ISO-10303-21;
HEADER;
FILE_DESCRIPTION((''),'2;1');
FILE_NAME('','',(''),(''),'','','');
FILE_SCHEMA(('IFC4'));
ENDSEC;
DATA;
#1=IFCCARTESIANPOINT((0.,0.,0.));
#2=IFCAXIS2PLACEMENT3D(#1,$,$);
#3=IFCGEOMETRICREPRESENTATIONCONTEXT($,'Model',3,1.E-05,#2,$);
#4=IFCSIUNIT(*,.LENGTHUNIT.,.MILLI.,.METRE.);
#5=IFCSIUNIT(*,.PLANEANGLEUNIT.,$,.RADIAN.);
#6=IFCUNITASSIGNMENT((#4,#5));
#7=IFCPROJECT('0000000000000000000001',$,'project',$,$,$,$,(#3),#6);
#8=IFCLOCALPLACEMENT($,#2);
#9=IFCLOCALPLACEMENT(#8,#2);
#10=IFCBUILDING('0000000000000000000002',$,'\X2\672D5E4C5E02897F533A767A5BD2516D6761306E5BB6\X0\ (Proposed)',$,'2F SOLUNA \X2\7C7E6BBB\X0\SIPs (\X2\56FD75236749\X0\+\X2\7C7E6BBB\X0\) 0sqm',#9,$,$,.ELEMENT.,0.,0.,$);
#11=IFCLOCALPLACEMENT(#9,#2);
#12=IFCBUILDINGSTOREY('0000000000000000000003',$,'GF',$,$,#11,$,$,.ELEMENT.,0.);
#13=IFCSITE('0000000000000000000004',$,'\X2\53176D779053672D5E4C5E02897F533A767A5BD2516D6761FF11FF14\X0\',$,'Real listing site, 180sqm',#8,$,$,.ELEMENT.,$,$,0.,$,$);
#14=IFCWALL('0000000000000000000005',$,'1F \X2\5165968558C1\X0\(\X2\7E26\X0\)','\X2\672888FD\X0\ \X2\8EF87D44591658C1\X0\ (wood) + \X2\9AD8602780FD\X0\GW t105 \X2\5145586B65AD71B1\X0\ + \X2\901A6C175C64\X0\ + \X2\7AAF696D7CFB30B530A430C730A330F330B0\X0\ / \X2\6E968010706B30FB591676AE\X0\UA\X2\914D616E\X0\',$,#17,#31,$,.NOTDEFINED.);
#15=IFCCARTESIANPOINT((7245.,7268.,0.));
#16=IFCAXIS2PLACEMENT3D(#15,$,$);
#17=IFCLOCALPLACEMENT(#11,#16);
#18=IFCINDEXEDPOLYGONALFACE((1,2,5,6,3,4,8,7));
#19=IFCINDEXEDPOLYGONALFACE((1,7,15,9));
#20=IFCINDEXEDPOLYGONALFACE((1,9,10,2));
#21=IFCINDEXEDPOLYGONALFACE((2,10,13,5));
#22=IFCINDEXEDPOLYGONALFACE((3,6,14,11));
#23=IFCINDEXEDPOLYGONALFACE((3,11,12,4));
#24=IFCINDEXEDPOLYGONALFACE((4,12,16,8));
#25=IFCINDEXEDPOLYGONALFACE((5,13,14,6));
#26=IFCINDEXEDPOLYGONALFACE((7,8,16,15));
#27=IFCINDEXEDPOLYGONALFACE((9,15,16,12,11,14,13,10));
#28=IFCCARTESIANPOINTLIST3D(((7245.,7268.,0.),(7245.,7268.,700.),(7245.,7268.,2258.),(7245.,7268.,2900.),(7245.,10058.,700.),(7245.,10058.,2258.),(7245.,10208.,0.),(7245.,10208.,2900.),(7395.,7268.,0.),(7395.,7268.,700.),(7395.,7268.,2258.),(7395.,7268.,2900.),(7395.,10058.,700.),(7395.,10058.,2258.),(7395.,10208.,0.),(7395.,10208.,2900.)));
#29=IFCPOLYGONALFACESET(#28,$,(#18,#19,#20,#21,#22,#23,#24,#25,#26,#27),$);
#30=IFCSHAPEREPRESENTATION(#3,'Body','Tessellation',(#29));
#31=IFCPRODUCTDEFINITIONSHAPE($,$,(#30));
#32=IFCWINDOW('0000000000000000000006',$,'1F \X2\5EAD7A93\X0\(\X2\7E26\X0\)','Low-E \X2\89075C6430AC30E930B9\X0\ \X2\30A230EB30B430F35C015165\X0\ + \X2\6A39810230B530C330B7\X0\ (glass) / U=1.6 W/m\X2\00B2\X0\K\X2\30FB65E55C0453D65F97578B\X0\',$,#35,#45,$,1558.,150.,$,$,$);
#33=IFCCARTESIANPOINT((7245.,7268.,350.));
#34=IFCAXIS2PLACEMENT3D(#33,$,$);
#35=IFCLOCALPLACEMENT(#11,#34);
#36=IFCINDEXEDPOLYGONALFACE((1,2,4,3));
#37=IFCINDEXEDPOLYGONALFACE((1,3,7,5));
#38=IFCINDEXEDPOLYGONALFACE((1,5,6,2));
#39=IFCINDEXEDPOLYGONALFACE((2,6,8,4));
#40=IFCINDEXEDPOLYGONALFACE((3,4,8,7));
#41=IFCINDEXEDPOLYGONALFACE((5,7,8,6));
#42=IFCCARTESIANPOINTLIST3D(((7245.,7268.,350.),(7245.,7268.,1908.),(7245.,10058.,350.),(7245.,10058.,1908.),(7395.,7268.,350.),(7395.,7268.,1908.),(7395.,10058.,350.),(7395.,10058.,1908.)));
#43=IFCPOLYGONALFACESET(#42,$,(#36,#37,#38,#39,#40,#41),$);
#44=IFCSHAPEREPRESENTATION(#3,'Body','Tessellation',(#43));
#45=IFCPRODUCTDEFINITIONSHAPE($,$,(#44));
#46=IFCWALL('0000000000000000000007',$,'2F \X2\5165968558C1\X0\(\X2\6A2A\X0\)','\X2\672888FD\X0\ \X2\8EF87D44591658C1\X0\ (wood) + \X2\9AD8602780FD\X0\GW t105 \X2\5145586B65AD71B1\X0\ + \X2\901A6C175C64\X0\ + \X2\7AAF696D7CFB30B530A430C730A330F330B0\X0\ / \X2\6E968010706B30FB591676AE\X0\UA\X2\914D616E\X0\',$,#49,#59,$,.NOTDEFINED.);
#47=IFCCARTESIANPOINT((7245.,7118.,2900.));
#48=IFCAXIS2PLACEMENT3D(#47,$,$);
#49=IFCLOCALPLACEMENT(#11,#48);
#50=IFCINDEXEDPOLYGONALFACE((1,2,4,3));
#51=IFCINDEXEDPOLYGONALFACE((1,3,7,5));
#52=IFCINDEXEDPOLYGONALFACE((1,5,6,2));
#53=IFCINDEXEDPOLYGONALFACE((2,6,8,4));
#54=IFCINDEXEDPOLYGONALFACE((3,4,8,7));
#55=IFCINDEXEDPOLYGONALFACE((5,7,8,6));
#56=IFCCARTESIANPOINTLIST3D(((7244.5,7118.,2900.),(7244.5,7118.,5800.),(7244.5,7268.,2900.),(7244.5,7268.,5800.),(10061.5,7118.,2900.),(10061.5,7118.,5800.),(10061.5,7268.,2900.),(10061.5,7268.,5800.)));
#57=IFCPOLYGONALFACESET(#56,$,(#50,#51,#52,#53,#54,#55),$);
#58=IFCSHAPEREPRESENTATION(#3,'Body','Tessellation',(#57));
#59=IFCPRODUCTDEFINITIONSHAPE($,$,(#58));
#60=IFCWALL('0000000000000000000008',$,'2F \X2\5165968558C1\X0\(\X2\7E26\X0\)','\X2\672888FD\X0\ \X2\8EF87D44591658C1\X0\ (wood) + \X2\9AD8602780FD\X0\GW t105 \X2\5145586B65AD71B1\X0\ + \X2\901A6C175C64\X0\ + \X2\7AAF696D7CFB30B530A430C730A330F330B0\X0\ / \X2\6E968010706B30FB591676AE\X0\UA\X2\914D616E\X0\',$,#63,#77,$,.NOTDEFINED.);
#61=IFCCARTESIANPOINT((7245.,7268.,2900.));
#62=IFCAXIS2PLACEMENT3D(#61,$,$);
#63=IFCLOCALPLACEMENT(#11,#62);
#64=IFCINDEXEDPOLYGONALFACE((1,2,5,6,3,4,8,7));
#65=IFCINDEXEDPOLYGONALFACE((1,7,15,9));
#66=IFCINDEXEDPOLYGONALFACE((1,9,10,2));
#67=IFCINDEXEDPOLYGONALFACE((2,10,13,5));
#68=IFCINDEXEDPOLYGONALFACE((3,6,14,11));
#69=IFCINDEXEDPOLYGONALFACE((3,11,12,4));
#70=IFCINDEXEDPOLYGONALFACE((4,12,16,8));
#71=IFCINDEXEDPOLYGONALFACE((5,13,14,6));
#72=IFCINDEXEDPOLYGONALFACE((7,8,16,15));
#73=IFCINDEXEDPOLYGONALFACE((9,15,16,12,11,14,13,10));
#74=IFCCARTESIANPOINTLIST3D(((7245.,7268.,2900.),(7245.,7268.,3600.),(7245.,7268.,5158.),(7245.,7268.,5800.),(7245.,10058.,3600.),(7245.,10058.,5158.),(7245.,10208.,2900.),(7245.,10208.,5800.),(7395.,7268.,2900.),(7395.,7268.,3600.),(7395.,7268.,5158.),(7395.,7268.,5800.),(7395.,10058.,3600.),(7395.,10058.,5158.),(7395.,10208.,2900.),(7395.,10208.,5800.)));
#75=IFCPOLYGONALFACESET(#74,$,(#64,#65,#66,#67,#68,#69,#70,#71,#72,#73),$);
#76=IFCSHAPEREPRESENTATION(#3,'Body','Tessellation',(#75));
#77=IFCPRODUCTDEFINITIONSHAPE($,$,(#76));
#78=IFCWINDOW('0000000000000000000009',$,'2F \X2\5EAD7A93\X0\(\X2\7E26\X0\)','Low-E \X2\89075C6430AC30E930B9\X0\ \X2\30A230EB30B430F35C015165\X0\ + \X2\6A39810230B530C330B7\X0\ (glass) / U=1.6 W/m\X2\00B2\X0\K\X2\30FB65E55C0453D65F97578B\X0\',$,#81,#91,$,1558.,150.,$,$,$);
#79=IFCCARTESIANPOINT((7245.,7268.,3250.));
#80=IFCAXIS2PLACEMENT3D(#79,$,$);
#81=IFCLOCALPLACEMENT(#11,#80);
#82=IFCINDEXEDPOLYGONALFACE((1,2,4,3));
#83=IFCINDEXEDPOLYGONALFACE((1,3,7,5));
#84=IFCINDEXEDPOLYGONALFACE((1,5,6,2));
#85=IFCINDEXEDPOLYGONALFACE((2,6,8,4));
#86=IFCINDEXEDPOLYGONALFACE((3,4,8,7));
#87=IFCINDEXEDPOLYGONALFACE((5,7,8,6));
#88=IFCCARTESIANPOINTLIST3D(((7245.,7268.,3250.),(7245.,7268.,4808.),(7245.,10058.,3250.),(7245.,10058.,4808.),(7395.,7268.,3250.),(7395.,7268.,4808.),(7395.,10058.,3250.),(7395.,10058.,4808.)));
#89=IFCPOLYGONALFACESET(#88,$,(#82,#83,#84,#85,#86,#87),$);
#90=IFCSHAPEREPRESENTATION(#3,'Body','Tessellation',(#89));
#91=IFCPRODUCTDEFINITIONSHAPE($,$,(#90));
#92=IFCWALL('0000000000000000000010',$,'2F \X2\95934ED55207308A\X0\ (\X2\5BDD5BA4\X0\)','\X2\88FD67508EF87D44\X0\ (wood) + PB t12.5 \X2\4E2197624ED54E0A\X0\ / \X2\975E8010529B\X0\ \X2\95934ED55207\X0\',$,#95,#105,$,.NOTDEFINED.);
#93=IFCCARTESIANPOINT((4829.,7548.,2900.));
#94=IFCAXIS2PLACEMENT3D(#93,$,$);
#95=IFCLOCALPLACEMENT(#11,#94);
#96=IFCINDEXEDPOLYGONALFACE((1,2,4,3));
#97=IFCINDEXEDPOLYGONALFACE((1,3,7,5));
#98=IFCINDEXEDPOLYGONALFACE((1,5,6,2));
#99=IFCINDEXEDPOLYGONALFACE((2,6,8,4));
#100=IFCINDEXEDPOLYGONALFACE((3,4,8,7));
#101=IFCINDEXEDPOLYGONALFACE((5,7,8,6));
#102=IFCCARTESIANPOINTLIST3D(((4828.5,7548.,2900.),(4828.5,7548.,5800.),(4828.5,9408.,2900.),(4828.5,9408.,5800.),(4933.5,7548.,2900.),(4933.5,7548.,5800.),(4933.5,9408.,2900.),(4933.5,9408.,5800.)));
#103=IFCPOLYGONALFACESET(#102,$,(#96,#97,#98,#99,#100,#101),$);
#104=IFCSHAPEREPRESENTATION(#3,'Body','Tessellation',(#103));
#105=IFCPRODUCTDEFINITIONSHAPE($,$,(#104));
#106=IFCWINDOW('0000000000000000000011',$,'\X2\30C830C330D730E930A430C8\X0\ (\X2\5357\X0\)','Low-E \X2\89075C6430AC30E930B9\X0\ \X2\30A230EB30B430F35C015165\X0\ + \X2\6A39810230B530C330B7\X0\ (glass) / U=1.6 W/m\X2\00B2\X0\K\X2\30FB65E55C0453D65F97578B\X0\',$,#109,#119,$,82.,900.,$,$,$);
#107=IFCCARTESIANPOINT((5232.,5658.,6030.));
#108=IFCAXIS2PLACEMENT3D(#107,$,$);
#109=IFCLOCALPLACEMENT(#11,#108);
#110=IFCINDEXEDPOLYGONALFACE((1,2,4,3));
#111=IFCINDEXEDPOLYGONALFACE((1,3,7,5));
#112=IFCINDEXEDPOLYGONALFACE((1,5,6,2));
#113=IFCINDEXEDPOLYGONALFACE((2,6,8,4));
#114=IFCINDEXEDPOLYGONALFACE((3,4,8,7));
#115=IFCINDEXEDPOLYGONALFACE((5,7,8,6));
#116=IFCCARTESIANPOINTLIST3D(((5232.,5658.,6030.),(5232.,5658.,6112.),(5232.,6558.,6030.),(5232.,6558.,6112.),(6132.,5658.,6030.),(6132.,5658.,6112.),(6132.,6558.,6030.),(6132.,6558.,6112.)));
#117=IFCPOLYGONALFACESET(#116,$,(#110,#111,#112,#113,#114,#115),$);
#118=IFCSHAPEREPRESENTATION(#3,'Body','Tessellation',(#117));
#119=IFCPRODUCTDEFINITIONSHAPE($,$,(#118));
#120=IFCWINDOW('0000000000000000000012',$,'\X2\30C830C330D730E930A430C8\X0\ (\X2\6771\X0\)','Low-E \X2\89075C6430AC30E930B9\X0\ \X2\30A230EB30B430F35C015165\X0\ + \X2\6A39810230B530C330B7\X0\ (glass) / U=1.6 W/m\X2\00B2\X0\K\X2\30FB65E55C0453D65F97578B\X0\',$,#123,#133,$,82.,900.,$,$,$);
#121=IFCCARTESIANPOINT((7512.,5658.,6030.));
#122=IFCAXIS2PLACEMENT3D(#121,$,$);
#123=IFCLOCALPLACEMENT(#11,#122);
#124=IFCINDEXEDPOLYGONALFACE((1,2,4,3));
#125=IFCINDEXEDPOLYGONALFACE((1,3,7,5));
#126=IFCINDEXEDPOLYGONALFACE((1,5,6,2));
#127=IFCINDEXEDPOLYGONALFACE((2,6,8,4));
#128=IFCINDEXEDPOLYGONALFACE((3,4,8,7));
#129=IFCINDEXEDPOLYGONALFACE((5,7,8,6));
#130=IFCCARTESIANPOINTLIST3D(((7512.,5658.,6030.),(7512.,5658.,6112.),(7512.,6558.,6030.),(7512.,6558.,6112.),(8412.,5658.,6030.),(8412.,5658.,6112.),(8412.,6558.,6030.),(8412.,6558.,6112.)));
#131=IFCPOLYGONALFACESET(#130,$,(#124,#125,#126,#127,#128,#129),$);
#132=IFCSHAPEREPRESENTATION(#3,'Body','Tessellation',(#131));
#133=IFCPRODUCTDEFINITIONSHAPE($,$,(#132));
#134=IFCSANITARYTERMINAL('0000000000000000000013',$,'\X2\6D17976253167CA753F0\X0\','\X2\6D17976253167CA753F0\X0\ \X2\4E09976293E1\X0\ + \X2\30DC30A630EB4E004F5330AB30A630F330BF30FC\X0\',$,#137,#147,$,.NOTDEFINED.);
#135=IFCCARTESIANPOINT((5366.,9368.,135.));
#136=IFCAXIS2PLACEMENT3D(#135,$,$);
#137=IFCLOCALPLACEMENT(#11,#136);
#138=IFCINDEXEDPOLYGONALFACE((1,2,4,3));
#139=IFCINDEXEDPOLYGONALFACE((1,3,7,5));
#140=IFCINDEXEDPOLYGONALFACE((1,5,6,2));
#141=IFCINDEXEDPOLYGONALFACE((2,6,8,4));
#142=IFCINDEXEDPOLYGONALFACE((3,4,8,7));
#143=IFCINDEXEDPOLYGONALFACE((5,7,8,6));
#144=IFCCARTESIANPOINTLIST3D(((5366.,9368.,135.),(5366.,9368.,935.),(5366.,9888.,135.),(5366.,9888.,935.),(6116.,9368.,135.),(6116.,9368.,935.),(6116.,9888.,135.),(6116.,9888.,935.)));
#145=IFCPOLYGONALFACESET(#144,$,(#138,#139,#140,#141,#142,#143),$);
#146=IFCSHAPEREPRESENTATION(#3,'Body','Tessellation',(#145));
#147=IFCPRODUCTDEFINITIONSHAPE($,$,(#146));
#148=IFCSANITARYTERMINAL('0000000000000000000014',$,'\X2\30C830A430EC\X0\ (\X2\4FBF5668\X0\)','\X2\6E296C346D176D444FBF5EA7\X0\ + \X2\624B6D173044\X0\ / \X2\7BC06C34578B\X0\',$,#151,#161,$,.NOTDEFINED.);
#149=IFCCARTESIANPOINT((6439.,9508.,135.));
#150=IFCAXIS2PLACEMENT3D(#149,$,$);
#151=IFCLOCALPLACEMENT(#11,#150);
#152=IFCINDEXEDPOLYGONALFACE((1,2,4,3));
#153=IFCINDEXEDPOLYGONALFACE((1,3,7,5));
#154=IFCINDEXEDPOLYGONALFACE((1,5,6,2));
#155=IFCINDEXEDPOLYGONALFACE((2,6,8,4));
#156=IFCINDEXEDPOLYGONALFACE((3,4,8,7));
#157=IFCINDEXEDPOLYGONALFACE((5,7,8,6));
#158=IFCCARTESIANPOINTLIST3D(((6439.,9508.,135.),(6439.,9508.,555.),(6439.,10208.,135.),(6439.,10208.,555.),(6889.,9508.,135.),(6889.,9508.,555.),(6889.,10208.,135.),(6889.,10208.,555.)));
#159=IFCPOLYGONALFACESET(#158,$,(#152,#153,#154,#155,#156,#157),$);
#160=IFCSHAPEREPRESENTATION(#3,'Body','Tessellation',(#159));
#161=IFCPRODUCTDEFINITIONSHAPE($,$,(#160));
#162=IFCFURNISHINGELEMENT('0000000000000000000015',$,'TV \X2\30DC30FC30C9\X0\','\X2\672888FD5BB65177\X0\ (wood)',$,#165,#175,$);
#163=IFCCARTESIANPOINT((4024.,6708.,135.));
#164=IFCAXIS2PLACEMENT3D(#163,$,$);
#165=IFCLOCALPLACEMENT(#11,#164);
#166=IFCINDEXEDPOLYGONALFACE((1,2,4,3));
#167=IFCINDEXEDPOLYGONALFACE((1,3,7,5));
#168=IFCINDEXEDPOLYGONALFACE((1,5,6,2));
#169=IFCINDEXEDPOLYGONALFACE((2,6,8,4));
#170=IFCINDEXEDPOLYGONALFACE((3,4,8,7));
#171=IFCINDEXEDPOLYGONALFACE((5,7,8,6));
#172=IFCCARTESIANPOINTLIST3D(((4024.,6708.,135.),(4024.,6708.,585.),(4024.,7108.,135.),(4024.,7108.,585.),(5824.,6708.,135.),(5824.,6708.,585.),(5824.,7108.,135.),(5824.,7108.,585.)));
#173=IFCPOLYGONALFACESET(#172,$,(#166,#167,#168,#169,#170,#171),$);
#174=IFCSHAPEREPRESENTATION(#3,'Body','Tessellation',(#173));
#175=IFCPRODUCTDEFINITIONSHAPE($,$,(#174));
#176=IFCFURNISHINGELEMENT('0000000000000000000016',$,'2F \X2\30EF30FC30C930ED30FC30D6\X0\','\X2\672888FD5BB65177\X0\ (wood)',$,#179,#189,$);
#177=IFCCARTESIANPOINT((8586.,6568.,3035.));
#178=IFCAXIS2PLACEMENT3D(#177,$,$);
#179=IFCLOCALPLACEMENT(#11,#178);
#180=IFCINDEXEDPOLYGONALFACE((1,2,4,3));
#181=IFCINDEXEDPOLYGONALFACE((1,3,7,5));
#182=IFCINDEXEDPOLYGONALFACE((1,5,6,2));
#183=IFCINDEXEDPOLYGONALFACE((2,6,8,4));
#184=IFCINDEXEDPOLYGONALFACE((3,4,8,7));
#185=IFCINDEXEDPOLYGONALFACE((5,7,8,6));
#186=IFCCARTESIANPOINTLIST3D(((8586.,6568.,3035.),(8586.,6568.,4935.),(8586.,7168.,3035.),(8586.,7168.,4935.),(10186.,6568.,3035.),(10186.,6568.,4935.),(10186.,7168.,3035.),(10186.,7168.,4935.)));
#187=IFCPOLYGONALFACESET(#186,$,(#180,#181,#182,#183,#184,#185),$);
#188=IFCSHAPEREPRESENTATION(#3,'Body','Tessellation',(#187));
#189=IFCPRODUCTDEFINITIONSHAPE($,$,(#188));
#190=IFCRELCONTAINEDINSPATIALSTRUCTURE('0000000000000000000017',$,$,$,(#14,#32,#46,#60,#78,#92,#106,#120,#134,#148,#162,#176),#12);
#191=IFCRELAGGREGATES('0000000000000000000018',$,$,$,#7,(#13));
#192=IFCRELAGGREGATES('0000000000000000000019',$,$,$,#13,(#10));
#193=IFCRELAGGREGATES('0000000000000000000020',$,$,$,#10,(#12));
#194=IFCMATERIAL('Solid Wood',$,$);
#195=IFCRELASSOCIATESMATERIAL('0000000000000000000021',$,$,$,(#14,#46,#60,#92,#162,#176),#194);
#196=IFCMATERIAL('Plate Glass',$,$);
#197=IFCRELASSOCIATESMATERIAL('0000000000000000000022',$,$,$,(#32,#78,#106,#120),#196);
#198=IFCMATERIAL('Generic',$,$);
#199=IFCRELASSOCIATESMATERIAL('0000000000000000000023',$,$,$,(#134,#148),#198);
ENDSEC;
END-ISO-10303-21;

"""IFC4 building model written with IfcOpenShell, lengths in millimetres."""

from ifc_helpers import new_model, si_unit, frame, frame_2d, origin, place, context, project, spatial, rectangle, extrude, material, element, fill, save


model = new_model("IFC4")

# Units and contexts
model_context = context("Model", 3, precision=1e-05, world=origin())
ifc_project = project(units=[si_unit("LENGTHUNIT", "METRE", prefix="MILLI"), si_unit("PLANEANGLEUNIT", "RADIAN")], contexts=[model_context])

# Site, building, storey
site_placement = place(None, origin())
site = spatial("IfcSite", under=ifc_project, at=site_placement, Name="北海道札幌市西区発寒六条１４", ObjectType="Real listing site, 180sqm", CompositionType="ELEMENT", RefElevation=0.0)
building_placement = place(site_placement, origin())
building = spatial("IfcBuilding", under=site, at=building_placement, Name="札幌市西区発寒六条の家 (Proposed)", ObjectType="2F SOLUNA 籾殻SIPs (国産杉+籾殻) 0sqm", CompositionType="ELEMENT", ElevationOfRefHeight=0.0, ElevationOfTerrain=0.0)
storey_placement = place(building_placement, origin())
storey = spatial("IfcBuildingStorey", under=building, at=storey_placement, Name="GF", CompositionType="ELEMENT", Elevation=0.0)

# Shared definitions
ifc_material_1 = material(Name="Solid Wood")

# Wall, opening, window
wall_1_placement = place(storey_placement, frame((7245.0, 7268.0, 0.0)))
wall_1 = element("IfcWall", 1, at=wall_1_placement, inside=storey, material=ifc_material_1, Name="1F 入隅壁(縦)", Description="木製 軸組外壁 (wood) + 高性能GW t105 充填断熱 + 通気層 + 窯業系サイディング / 準耐火・外皮UA配慮", PredefinedType="NOTDEFINED", context=model_context, shape_type="SweptSolid", body=[
    extrude(rectangle(XDim=150.0, YDim=2940.0, at=frame_2d((75.0, 1470.0))), frame((7245.0, 7268.0, 0.0)), (0.0, 0.0, 1.0), 2900.0),
])
opening_1_placement = place(storey_placement, frame((7245.0, 7268.0, 350.0)))
opening_1 = element("IfcOpeningElement", 2, at=opening_1_placement, cuts=wall_1, PredefinedType="NOTDEFINED", context=model_context, shape_type="SweptSolid", body=[
    extrude(rectangle(XDim=150.0, YDim=2790.0, at=frame_2d((75.0, 1395.0))), frame((7245.0, 7268.0, 350.0)), (0.0, 0.0, 1.0), 1558.0),
])
ifc_material_2 = material(Name="Plate Glass")
window_1_placement = place(storey_placement, frame((7245.0, 7268.0, 350.0)))
window_1 = element("IfcWindow", 3, at=window_1_placement, inside=storey, material=ifc_material_2, Name="1F 庭窓(縦)", Description="Low-E 複層ガラス アルゴン封入 + 樹脂サッシ (glass) / U=1.6 W/m²K・日射取得型", OverallHeight=1558.0, OverallWidth=150.0, context=model_context, shape_type="SweptSolid", body=[
    extrude(rectangle(XDim=150.0, YDim=2790.0, at=frame_2d((75.0, 1395.0))), frame((7245.0, 7268.0, 350.0)), (0.0, 0.0, 1.0), 1558.0),
])
fill(opening_1, window_1)

# Wall
wall_2_placement = place(storey_placement, frame((7245.0, 7118.0, 2900.0)))
element("IfcWall", 4, at=wall_2_placement, inside=storey, material=ifc_material_1, Name="2F 入隅壁(横)", Description="木製 軸組外壁 (wood) + 高性能GW t105 充填断熱 + 通気層 + 窯業系サイディング / 準耐火・外皮UA配慮", PredefinedType="NOTDEFINED", context=model_context, shape_type="SweptSolid", body=[
    extrude(rectangle(XDim=2817.0, YDim=150.0, at=frame_2d((1408.0, 75.0))), frame((7245.0, 7118.0, 2900.0)), (0.0, 0.0, 1.0), 2900.0),
])

# Wall, opening, window
wall_3_placement = place(storey_placement, frame((7245.0, 7268.0, 2900.0)))
wall_3 = element("IfcWall", 5, at=wall_3_placement, inside=storey, material=ifc_material_1, Name="2F 入隅壁(縦)", Description="木製 軸組外壁 (wood) + 高性能GW t105 充填断熱 + 通気層 + 窯業系サイディング / 準耐火・外皮UA配慮", PredefinedType="NOTDEFINED", context=model_context, shape_type="SweptSolid", body=[
    extrude(rectangle(XDim=150.0, YDim=2940.0, at=frame_2d((75.0, 1470.0))), frame((7245.0, 7268.0, 2900.0)), (0.0, 0.0, 1.0), 2900.0),
])
opening_2_placement = place(storey_placement, frame((7245.0, 7268.0, 3250.0)))
opening_2 = element("IfcOpeningElement", 6, at=opening_2_placement, cuts=wall_3, PredefinedType="NOTDEFINED", context=model_context, shape_type="SweptSolid", body=[
    extrude(rectangle(XDim=150.0, YDim=2790.0, at=frame_2d((75.0, 1395.0))), frame((7245.0, 7268.0, 3250.0)), (0.0, 0.0, 1.0), 1558.0),
])
window_2_placement = place(storey_placement, frame((7245.0, 7268.0, 3250.0)))
window_2 = element("IfcWindow", 7, at=window_2_placement, inside=storey, material=ifc_material_2, Name="2F 庭窓(縦)", Description="Low-E 複層ガラス アルゴン封入 + 樹脂サッシ (glass) / U=1.6 W/m²K・日射取得型", OverallHeight=1558.0, OverallWidth=150.0, context=model_context, shape_type="SweptSolid", body=[
    extrude(rectangle(XDim=150.0, YDim=2790.0, at=frame_2d((75.0, 1395.0))), frame((7245.0, 7268.0, 3250.0)), (0.0, 0.0, 1.0), 1558.0),
])
fill(opening_2, window_2)

# Wall
wall_4_placement = place(storey_placement, frame((4829.0, 7548.0, 2900.0)))
element("IfcWall", 8, at=wall_4_placement, inside=storey, material=ifc_material_1, Name="2F 間仕切り (寝室)", Description="製材軸組 (wood) + PB t12.5 両面仕上 / 非耐力 間仕切", PredefinedType="NOTDEFINED", context=model_context, shape_type="SweptSolid", body=[
    extrude(rectangle(XDim=105.0, YDim=1860.0, at=frame_2d((52.0, 930.0))), frame((4829.0, 7548.0, 2900.0)), (0.0, 0.0, 1.0), 2900.0),
])

# Windows
window_3_placement = place(storey_placement, frame((5232.0, 5658.0, 6030.0)))
element("IfcWindow", 9, at=window_3_placement, inside=storey, material=ifc_material_2, Name="トップライト (南)", Description="Low-E 複層ガラス アルゴン封入 + 樹脂サッシ (glass) / U=1.6 W/m²K・日射取得型", OverallHeight=82.0, OverallWidth=900.0, context=model_context, shape_type="SweptSolid", body=[
    extrude(rectangle(XDim=900.0, YDim=900.0, at=frame_2d((450.0, 450.0))), frame((5232.0, 5658.0, 6030.0)), (0.0, 0.0, 1.0), 82.0),
])
window_4_placement = place(storey_placement, frame((7512.0, 5658.0, 6030.0)))
element("IfcWindow", 10, at=window_4_placement, inside=storey, material=ifc_material_2, Name="トップライト (東)", Description="Low-E 複層ガラス アルゴン封入 + 樹脂サッシ (glass) / U=1.6 W/m²K・日射取得型", OverallHeight=82.0, OverallWidth=900.0, context=model_context, shape_type="SweptSolid", body=[
    extrude(rectangle(XDim=900.0, YDim=900.0, at=frame_2d((450.0, 450.0))), frame((7512.0, 5658.0, 6030.0)), (0.0, 0.0, 1.0), 82.0),
])

# Sanitary terminals
ifc_material_3 = material(Name="Generic")
sanitary_terminal_1_placement = place(storey_placement, frame((5366.0, 9368.0, 135.0)))
element("IfcSanitaryTerminal", 11, at=sanitary_terminal_1_placement, inside=storey, material=ifc_material_3, Name="洗面化粧台", Description="洗面化粧台 三面鏡 + ボウル一体カウンター", PredefinedType="NOTDEFINED", context=model_context, shape_type="SweptSolid", body=[
    extrude(rectangle(XDim=750.0, YDim=520.0, at=frame_2d((375.0, 260.0))), frame((5366.0, 9368.0, 135.0)), (0.0, 0.0, 1.0), 800.0),
])
sanitary_terminal_2_placement = place(storey_placement, frame((6439.0, 9508.0, 135.0)))
element("IfcSanitaryTerminal", 12, at=sanitary_terminal_2_placement, inside=storey, material=ifc_material_3, Name="トイレ (便器)", Description="温水洗浄便座 + 手洗い / 節水型", PredefinedType="NOTDEFINED", context=model_context, shape_type="SweptSolid", body=[
    extrude(rectangle(XDim=450.0, YDim=700.0, at=frame_2d((225.0, 350.0))), frame((6439.0, 9508.0, 135.0)), (0.0, 0.0, 1.0), 420.0),
])

# Furnishing elements
furnishing_1_placement = place(storey_placement, frame((4024.0, 6708.0, 135.0)))
element("IfcFurnishingElement", 13, at=furnishing_1_placement, inside=storey, material=ifc_material_1, Name="TV ボード", Description="木製家具 (wood)", context=model_context, shape_type="SweptSolid", body=[
    extrude(rectangle(XDim=1800.0, YDim=400.0, at=frame_2d((900.0, 200.0))), frame((4024.0, 6708.0, 135.0)), (0.0, 0.0, 1.0), 450.0),
])
furnishing_2_placement = place(storey_placement, frame((8586.0, 6568.0, 3035.0)))
element("IfcFurnishingElement", 14, at=furnishing_2_placement, inside=storey, material=ifc_material_1, Name="2F ワードローブ", Description="木製家具 (wood)", context=model_context, shape_type="SweptSolid", body=[
    extrude(rectangle(XDim=1600.0, YDim=600.0, at=frame_2d((800.0, 300.0))), frame((8586.0, 6568.0, 3035.0)), (0.0, 0.0, 1.0), 1900.0),
])

save(model, "model.ifc")
